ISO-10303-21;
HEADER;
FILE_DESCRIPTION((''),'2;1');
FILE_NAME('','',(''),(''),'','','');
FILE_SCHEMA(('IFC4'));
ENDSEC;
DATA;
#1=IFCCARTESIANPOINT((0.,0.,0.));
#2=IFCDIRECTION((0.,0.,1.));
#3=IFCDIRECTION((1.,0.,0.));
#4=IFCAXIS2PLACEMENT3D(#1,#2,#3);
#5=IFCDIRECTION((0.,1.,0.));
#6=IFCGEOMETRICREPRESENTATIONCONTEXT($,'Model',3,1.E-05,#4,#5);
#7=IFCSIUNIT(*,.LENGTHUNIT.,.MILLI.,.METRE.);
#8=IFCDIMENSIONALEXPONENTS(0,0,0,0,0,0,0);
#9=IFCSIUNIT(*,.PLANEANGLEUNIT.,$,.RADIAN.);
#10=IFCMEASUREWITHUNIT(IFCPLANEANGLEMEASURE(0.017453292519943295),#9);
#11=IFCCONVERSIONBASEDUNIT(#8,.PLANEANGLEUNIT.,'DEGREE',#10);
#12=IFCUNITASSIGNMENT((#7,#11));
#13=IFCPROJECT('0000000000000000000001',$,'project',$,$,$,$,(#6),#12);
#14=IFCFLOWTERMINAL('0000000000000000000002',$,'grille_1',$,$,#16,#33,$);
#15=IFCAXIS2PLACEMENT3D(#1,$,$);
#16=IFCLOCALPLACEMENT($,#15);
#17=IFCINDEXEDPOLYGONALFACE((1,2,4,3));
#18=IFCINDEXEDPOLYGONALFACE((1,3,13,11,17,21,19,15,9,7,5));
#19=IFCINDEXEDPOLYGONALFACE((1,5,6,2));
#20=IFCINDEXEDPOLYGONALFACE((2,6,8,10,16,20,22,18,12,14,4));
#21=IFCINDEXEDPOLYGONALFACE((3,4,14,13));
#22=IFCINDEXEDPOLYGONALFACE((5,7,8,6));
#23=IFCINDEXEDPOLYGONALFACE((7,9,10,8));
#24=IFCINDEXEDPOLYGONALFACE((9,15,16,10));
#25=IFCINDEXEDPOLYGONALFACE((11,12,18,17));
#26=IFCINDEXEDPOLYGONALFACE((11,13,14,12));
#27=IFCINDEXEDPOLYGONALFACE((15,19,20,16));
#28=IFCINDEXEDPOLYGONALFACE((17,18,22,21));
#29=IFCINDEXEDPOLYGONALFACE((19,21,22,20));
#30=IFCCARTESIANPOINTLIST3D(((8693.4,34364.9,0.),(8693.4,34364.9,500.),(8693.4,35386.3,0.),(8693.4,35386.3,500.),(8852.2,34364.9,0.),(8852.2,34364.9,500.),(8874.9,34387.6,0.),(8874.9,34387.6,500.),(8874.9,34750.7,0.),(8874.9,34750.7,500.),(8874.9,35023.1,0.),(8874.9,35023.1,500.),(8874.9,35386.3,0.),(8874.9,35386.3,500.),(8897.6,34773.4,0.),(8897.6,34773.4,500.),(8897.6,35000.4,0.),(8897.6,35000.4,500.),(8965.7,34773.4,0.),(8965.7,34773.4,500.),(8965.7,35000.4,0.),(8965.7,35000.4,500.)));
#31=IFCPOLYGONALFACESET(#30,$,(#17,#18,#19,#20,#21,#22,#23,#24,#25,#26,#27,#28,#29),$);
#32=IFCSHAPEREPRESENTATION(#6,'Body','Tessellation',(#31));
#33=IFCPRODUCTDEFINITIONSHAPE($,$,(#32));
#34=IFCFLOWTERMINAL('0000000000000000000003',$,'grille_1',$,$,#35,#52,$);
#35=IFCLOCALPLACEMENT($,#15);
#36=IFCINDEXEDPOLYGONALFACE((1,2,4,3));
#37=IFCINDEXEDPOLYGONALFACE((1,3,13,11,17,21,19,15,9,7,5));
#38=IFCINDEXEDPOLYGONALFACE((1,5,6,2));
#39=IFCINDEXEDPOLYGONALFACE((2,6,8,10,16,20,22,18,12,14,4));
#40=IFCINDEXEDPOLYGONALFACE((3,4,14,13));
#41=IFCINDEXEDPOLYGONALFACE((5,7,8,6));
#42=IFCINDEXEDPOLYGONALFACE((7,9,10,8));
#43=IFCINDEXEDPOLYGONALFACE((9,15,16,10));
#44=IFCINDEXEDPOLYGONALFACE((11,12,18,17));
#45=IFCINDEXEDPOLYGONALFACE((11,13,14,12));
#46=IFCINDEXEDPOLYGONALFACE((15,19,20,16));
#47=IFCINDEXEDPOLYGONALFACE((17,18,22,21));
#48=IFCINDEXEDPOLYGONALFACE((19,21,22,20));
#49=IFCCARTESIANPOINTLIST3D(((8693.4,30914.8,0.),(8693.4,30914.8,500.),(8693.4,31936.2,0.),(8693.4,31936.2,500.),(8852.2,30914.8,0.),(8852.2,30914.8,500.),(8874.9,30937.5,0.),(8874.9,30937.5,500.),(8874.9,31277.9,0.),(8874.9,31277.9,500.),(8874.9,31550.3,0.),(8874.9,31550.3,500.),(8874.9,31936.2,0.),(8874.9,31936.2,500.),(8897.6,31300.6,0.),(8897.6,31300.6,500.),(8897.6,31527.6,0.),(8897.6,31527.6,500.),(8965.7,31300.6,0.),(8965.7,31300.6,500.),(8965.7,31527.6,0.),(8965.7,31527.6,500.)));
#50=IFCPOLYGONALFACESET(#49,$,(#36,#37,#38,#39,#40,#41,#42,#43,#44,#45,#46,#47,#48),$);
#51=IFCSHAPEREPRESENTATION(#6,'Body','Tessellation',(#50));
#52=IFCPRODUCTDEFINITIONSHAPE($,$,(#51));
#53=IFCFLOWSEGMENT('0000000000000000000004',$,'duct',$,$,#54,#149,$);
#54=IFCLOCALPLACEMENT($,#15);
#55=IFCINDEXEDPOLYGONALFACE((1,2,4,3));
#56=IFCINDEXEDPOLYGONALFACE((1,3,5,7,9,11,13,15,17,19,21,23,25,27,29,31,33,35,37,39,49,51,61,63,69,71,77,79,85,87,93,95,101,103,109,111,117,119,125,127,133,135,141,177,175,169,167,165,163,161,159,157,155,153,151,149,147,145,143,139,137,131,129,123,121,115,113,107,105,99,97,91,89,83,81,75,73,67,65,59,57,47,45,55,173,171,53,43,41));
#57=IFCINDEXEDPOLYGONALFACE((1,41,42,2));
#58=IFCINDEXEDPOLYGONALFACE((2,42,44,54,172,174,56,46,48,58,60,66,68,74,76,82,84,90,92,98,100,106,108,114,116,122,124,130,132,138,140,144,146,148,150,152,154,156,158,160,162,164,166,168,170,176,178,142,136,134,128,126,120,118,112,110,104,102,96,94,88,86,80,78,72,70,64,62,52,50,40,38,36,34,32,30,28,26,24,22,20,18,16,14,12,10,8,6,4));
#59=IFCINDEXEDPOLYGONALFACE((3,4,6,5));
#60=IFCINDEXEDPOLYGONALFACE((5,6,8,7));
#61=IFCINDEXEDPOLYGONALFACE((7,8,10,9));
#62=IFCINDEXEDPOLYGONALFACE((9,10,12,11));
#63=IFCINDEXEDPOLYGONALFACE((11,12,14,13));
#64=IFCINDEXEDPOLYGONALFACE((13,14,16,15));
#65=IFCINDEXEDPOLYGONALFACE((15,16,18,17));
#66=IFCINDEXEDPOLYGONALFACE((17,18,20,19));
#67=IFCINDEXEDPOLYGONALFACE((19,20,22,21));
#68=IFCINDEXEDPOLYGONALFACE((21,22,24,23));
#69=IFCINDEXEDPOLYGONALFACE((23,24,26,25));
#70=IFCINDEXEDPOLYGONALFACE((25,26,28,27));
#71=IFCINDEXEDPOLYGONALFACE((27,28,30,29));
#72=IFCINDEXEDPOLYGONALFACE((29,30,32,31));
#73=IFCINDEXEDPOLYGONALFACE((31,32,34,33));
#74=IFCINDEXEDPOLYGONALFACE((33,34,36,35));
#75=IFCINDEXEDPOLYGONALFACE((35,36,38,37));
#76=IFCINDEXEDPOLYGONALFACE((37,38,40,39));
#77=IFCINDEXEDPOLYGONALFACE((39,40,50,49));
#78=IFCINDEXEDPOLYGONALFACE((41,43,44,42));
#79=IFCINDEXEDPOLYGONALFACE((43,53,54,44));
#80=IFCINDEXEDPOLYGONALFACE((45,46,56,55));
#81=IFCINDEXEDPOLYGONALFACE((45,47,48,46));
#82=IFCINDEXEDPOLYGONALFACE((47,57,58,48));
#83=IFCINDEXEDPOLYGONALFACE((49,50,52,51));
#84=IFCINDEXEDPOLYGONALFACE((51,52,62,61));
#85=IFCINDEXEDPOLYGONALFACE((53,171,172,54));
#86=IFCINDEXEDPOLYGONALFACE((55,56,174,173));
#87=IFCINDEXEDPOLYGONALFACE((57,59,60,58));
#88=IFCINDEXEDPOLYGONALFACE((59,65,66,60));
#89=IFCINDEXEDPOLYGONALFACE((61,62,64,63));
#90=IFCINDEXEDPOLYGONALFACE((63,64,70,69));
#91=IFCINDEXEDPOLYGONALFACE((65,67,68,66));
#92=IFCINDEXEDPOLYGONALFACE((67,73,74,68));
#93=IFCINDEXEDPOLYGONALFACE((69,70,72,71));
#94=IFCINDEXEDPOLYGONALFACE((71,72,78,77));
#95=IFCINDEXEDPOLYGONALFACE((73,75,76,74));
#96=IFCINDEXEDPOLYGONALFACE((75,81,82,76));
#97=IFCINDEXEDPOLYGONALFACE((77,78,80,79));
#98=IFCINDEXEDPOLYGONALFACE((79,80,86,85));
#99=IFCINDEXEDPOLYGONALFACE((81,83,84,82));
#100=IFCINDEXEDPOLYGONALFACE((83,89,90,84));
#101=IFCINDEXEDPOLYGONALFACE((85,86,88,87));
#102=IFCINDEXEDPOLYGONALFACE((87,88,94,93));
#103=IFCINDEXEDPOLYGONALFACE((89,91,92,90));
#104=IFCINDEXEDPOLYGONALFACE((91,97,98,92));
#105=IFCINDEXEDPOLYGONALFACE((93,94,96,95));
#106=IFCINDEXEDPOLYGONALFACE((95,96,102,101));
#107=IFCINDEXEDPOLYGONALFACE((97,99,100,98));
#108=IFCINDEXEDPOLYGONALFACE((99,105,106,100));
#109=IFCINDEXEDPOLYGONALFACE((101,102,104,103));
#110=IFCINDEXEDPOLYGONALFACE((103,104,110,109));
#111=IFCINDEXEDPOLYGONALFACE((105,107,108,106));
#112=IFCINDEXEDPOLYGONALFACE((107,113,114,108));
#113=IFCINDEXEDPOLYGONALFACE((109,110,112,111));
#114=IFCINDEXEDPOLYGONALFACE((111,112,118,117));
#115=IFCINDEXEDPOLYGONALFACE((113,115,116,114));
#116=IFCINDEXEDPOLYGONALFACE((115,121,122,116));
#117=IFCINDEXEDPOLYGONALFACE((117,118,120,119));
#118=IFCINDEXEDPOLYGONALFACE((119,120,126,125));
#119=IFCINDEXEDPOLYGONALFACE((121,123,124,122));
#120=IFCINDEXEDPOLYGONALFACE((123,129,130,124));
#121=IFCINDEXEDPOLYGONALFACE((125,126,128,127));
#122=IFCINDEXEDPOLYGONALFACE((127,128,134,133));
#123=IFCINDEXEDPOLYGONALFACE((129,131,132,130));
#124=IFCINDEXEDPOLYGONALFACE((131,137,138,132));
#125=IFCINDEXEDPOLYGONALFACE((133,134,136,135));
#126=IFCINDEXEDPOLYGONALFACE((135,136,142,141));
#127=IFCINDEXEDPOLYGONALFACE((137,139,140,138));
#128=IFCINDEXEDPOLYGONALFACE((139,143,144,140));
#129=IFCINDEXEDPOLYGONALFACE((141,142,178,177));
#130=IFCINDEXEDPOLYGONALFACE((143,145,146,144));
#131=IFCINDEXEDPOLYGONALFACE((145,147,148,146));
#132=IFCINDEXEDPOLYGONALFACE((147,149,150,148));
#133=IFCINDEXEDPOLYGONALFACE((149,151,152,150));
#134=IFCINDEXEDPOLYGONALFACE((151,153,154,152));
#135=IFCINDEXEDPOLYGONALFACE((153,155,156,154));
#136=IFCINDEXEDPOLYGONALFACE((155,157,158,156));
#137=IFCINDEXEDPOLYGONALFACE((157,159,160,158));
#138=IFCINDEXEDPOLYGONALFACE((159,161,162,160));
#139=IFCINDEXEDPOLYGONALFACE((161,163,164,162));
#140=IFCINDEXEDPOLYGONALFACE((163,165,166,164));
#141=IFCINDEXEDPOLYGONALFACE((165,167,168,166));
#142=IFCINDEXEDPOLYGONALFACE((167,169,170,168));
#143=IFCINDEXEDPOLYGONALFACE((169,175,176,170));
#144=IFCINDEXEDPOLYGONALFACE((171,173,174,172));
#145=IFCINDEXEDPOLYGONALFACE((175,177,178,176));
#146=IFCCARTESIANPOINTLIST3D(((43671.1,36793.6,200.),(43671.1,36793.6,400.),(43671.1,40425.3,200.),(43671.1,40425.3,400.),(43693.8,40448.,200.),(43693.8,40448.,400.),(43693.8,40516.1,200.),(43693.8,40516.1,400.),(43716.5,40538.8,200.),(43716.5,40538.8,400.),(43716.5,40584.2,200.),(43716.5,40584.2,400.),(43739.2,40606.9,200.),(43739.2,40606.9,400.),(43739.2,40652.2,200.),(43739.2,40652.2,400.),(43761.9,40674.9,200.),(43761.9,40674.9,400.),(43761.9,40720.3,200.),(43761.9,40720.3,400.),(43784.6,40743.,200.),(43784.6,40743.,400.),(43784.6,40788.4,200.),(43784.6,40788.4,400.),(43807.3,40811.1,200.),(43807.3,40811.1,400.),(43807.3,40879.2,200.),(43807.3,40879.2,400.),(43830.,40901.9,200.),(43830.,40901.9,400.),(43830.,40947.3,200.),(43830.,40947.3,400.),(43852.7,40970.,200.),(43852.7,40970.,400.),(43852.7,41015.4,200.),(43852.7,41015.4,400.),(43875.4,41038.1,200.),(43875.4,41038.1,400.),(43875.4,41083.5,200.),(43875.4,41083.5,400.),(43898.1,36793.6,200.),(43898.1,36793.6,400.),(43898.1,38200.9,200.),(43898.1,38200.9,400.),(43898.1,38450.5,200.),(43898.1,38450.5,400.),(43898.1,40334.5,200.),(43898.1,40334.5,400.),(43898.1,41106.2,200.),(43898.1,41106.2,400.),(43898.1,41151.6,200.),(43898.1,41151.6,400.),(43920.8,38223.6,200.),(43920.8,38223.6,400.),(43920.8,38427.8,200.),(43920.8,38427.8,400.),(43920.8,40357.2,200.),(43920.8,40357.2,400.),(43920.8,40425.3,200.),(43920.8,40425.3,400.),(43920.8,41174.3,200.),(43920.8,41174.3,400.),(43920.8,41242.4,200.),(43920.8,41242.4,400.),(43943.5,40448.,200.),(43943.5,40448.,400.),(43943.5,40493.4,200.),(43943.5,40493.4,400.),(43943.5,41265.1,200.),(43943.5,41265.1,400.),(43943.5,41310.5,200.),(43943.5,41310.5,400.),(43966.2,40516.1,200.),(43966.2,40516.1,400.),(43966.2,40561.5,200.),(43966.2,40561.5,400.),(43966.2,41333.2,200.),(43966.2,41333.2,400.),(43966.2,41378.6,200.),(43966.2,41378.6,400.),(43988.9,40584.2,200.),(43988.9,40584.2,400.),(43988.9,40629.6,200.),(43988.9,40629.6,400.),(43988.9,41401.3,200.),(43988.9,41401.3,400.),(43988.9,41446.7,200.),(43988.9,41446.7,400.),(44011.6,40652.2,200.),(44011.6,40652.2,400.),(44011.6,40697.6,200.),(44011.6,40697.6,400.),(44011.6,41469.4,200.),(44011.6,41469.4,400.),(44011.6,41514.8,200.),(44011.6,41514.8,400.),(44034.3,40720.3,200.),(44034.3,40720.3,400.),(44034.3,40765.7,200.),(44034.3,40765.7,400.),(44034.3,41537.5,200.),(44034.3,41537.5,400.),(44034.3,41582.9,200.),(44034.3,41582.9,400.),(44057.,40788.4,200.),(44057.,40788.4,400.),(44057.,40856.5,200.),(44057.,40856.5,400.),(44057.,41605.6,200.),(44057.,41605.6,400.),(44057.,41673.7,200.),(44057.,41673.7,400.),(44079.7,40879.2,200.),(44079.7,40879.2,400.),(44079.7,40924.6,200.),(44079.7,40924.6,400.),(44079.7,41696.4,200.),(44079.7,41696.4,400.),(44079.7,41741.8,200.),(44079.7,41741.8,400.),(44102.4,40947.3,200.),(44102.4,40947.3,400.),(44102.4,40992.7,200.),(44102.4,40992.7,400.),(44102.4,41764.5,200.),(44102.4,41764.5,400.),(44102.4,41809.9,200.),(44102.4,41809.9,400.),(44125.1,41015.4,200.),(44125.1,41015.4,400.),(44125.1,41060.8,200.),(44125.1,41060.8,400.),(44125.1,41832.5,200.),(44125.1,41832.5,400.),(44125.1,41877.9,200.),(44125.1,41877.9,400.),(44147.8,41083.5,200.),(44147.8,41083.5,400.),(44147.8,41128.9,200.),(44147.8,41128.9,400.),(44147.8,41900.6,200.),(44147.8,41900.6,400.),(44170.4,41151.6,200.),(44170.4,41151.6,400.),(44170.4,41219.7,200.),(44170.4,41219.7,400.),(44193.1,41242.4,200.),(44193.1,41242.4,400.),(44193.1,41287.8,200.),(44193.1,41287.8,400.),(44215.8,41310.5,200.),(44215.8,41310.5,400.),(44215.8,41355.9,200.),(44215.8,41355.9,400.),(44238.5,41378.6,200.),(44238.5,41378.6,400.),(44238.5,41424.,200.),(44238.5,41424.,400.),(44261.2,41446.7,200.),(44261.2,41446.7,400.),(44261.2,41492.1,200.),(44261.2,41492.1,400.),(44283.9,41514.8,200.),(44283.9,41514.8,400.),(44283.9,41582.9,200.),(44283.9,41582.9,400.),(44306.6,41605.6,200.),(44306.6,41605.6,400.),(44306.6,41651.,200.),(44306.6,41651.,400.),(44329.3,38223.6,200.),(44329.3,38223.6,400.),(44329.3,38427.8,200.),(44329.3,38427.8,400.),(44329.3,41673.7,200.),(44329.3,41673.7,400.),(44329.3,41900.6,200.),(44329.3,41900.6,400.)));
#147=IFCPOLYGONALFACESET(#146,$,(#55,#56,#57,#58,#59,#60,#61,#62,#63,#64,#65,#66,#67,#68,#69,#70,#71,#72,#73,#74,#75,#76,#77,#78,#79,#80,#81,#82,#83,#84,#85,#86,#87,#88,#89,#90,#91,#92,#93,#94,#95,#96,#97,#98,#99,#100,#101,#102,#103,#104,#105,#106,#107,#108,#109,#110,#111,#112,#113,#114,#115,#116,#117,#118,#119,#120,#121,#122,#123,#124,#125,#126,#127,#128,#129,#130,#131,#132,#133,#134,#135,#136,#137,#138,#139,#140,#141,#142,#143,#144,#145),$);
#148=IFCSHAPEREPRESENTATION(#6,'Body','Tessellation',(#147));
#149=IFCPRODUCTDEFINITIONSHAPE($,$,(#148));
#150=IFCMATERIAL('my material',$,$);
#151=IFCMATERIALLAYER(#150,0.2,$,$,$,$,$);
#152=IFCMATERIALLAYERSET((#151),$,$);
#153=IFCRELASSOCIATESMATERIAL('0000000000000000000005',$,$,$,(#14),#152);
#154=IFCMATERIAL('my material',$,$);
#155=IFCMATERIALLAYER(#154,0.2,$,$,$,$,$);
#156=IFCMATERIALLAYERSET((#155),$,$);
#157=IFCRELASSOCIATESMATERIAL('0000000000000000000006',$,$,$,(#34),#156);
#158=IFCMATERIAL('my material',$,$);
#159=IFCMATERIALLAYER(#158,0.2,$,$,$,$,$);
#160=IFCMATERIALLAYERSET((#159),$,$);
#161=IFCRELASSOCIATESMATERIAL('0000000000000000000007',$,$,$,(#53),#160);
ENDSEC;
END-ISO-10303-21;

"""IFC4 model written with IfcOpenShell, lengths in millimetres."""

from ifc_helpers import new_model, entity, si_unit, converted_unit, direction, frame, origin_with_axes, place, context, project, polyline, outline, extrude, material, layer, layer_set, layer_usage, element, save


model = new_model("IFC4")

# Units and contexts
model_context = context("Model", 3, precision=1e-05, world=origin_with_axes(), true_north=direction((0.0, 1.0, 0.0)))
ifc_project = project(units=[si_unit("LENGTHUNIT", "METRE", prefix="MILLI"), converted_unit("PLANEANGLEUNIT", "DEGREE", entity("IfcPlaneAngleMeasure", 0.017453292519943295), si_unit("PLANEANGLEUNIT", "RADIAN"), dimensions=[0, 0, 0, 0, 0, 0, 0])], contexts=[model_context])

# Flow terminals
ifc_material_1 = material(Name="my material")
ifc_layer_1 = layer(ifc_material_1, 0.2)
ifc_layer_set_1 = layer_set([ifc_layer_1])
ifc_layer_usage_1 = layer_usage(ifc_layer_set_1, "AXIS2", "POSITIVE", -0.1)
flow_terminal_1_placement = place(None, origin_with_axes())
element("IfcFlowTerminal", 1, at=flow_terminal_1_placement, material=ifc_layer_usage_1, Name="grille_1", context=model_context, shape_type="SweptSolid", body=[
    extrude(outline(polyline([(8693.4, 34364.9), (8852.2, 34364.9), (8874.9, 34387.6), (8874.9, 34750.7), (8897.6, 34773.4), (8965.7, 34773.4), (8965.7, 35000.4), (8897.6, 35000.4), (8874.9, 35023.1), (8874.9, 35386.3), (8693.4, 35386.3), (8693.4, 34364.9)])), origin_with_axes(), (0.0, 0.0, 1.0), 500.0),
])
ifc_material_2 = material(Name="my material")
ifc_layer_2 = layer(ifc_material_2, 0.2)
ifc_layer_set_2 = layer_set([ifc_layer_2])
ifc_layer_usage_2 = layer_usage(ifc_layer_set_2, "AXIS2", "POSITIVE", -0.1)
flow_terminal_2_placement = place(None, origin_with_axes())
element("IfcFlowTerminal", 2, at=flow_terminal_2_placement, material=ifc_layer_usage_2, Name="grille_1", context=model_context, shape_type="SweptSolid", body=[
    extrude(outline(polyline([(8693.4, 30914.8), (8852.2, 30914.8), (8874.9, 30937.5), (8874.9, 31277.9), (8897.6, 31300.6), (8965.7, 31300.6), (8965.7, 31527.6), (8897.6, 31527.6), (8874.9, 31550.3), (8874.9, 31936.2), (8693.4, 31936.2), (8693.4, 30914.8)])), origin_with_axes(), (0.0, 0.0, 1.0), 500.0),
])

# Flow segment
ifc_material_3 = material(Name="my material")
ifc_layer_3 = layer(ifc_material_3, 0.2)
ifc_layer_set_3 = layer_set([ifc_layer_3])
ifc_layer_usage_3 = layer_usage(ifc_layer_set_3, "AXIS2", "POSITIVE", -0.1)
flow_segment_1_placement = place(None, origin_with_axes())
element("IfcFlowSegment", 3, at=flow_segment_1_placement, material=ifc_layer_usage_3, Name="duct", context=model_context, shape_type="SweptSolid", body=[
    extrude(outline(polyline([(43671.1, 36793.6), (43898.1, 36793.6), (43898.1, 38200.9), (43920.8, 38223.6), (44329.3, 38223.6), (44329.3, 38427.8), (43920.8, 38427.8), (43898.1, 38450.5), (43898.1, 40334.5), (43920.8, 40357.2), (43920.8, 40425.3), (43943.5, 40448.0), (43943.5, 40493.4), (43966.2, 40516.1), (43966.2, 40561.5), (43988.9, 40584.2), (43988.9, 40629.6), (44011.6, 40652.2), (44011.6, 40697.6), (44034.3, 40720.3), (44034.3, 40765.7), (44057.0, 40788.4), (44057.0, 40856.5), (44079.7, 40879.2), (44079.7, 40924.6), (44102.4, 40947.3), (44102.4, 40992.7), (44125.1, 41015.4), (44125.1, 41060.8), (44147.8, 41083.5), (44147.8, 41128.9), (44170.4, 41151.6), (44170.4, 41219.7), (44193.1, 41242.4), (44193.1, 41287.8), (44215.8, 41310.5), (44215.8, 41355.9), (44238.5, 41378.6), (44238.5, 41424.0), (44261.2, 41446.7), (44261.2, 41492.1), (44283.9, 41514.8), (44283.9, 41582.9), (44306.6, 41605.6), (44306.6, 41651.0), (44329.3, 41673.7), (44329.3, 41900.6), (44147.8, 41900.6), (44125.1, 41877.9), (44125.1, 41832.5), (44102.4, 41809.9), (44102.4, 41764.5), (44079.7, 41741.8), (44079.7, 41696.4), (44057.0, 41673.7), (44057.0, 41605.6), (44034.3, 41582.9), (44034.3, 41537.5), (44011.6, 41514.8), (44011.6, 41469.4), (43988.9, 41446.7), (43988.9, 41401.3), (43966.2, 41378.6), (43966.2, 41333.2), (43943.5, 41310.5), (43943.5, 41265.1), (43920.8, 41242.4), (43920.8, 41174.3), (43898.1, 41151.6), (43898.1, 41106.2), (43875.4, 41083.5), (43875.4, 41038.1), (43852.7, 41015.4), (43852.7, 40970.0), (43830.0, 40947.3), (43830.0, 40901.9), (43807.3, 40879.2), (43807.3, 40811.1), (43784.6, 40788.4), (43784.6, 40743.0), (43761.9, 40720.3), (43761.9, 40674.9), (43739.2, 40652.2), (43739.2, 40606.9), (43716.5, 40584.2), (43716.5, 40538.8), (43693.8, 40516.1), (43693.8, 40448.0), (43671.1, 40425.3), (43671.1, 36793.6)])), frame((0.0, 0.0, 200.0), z_axis=(0.0, 0.0, 1.0), x_axis=(1.0, 0.0, 0.0)), (0.0, 0.0, 1.0), 200.0),
])

save(model, "model.ifc")
